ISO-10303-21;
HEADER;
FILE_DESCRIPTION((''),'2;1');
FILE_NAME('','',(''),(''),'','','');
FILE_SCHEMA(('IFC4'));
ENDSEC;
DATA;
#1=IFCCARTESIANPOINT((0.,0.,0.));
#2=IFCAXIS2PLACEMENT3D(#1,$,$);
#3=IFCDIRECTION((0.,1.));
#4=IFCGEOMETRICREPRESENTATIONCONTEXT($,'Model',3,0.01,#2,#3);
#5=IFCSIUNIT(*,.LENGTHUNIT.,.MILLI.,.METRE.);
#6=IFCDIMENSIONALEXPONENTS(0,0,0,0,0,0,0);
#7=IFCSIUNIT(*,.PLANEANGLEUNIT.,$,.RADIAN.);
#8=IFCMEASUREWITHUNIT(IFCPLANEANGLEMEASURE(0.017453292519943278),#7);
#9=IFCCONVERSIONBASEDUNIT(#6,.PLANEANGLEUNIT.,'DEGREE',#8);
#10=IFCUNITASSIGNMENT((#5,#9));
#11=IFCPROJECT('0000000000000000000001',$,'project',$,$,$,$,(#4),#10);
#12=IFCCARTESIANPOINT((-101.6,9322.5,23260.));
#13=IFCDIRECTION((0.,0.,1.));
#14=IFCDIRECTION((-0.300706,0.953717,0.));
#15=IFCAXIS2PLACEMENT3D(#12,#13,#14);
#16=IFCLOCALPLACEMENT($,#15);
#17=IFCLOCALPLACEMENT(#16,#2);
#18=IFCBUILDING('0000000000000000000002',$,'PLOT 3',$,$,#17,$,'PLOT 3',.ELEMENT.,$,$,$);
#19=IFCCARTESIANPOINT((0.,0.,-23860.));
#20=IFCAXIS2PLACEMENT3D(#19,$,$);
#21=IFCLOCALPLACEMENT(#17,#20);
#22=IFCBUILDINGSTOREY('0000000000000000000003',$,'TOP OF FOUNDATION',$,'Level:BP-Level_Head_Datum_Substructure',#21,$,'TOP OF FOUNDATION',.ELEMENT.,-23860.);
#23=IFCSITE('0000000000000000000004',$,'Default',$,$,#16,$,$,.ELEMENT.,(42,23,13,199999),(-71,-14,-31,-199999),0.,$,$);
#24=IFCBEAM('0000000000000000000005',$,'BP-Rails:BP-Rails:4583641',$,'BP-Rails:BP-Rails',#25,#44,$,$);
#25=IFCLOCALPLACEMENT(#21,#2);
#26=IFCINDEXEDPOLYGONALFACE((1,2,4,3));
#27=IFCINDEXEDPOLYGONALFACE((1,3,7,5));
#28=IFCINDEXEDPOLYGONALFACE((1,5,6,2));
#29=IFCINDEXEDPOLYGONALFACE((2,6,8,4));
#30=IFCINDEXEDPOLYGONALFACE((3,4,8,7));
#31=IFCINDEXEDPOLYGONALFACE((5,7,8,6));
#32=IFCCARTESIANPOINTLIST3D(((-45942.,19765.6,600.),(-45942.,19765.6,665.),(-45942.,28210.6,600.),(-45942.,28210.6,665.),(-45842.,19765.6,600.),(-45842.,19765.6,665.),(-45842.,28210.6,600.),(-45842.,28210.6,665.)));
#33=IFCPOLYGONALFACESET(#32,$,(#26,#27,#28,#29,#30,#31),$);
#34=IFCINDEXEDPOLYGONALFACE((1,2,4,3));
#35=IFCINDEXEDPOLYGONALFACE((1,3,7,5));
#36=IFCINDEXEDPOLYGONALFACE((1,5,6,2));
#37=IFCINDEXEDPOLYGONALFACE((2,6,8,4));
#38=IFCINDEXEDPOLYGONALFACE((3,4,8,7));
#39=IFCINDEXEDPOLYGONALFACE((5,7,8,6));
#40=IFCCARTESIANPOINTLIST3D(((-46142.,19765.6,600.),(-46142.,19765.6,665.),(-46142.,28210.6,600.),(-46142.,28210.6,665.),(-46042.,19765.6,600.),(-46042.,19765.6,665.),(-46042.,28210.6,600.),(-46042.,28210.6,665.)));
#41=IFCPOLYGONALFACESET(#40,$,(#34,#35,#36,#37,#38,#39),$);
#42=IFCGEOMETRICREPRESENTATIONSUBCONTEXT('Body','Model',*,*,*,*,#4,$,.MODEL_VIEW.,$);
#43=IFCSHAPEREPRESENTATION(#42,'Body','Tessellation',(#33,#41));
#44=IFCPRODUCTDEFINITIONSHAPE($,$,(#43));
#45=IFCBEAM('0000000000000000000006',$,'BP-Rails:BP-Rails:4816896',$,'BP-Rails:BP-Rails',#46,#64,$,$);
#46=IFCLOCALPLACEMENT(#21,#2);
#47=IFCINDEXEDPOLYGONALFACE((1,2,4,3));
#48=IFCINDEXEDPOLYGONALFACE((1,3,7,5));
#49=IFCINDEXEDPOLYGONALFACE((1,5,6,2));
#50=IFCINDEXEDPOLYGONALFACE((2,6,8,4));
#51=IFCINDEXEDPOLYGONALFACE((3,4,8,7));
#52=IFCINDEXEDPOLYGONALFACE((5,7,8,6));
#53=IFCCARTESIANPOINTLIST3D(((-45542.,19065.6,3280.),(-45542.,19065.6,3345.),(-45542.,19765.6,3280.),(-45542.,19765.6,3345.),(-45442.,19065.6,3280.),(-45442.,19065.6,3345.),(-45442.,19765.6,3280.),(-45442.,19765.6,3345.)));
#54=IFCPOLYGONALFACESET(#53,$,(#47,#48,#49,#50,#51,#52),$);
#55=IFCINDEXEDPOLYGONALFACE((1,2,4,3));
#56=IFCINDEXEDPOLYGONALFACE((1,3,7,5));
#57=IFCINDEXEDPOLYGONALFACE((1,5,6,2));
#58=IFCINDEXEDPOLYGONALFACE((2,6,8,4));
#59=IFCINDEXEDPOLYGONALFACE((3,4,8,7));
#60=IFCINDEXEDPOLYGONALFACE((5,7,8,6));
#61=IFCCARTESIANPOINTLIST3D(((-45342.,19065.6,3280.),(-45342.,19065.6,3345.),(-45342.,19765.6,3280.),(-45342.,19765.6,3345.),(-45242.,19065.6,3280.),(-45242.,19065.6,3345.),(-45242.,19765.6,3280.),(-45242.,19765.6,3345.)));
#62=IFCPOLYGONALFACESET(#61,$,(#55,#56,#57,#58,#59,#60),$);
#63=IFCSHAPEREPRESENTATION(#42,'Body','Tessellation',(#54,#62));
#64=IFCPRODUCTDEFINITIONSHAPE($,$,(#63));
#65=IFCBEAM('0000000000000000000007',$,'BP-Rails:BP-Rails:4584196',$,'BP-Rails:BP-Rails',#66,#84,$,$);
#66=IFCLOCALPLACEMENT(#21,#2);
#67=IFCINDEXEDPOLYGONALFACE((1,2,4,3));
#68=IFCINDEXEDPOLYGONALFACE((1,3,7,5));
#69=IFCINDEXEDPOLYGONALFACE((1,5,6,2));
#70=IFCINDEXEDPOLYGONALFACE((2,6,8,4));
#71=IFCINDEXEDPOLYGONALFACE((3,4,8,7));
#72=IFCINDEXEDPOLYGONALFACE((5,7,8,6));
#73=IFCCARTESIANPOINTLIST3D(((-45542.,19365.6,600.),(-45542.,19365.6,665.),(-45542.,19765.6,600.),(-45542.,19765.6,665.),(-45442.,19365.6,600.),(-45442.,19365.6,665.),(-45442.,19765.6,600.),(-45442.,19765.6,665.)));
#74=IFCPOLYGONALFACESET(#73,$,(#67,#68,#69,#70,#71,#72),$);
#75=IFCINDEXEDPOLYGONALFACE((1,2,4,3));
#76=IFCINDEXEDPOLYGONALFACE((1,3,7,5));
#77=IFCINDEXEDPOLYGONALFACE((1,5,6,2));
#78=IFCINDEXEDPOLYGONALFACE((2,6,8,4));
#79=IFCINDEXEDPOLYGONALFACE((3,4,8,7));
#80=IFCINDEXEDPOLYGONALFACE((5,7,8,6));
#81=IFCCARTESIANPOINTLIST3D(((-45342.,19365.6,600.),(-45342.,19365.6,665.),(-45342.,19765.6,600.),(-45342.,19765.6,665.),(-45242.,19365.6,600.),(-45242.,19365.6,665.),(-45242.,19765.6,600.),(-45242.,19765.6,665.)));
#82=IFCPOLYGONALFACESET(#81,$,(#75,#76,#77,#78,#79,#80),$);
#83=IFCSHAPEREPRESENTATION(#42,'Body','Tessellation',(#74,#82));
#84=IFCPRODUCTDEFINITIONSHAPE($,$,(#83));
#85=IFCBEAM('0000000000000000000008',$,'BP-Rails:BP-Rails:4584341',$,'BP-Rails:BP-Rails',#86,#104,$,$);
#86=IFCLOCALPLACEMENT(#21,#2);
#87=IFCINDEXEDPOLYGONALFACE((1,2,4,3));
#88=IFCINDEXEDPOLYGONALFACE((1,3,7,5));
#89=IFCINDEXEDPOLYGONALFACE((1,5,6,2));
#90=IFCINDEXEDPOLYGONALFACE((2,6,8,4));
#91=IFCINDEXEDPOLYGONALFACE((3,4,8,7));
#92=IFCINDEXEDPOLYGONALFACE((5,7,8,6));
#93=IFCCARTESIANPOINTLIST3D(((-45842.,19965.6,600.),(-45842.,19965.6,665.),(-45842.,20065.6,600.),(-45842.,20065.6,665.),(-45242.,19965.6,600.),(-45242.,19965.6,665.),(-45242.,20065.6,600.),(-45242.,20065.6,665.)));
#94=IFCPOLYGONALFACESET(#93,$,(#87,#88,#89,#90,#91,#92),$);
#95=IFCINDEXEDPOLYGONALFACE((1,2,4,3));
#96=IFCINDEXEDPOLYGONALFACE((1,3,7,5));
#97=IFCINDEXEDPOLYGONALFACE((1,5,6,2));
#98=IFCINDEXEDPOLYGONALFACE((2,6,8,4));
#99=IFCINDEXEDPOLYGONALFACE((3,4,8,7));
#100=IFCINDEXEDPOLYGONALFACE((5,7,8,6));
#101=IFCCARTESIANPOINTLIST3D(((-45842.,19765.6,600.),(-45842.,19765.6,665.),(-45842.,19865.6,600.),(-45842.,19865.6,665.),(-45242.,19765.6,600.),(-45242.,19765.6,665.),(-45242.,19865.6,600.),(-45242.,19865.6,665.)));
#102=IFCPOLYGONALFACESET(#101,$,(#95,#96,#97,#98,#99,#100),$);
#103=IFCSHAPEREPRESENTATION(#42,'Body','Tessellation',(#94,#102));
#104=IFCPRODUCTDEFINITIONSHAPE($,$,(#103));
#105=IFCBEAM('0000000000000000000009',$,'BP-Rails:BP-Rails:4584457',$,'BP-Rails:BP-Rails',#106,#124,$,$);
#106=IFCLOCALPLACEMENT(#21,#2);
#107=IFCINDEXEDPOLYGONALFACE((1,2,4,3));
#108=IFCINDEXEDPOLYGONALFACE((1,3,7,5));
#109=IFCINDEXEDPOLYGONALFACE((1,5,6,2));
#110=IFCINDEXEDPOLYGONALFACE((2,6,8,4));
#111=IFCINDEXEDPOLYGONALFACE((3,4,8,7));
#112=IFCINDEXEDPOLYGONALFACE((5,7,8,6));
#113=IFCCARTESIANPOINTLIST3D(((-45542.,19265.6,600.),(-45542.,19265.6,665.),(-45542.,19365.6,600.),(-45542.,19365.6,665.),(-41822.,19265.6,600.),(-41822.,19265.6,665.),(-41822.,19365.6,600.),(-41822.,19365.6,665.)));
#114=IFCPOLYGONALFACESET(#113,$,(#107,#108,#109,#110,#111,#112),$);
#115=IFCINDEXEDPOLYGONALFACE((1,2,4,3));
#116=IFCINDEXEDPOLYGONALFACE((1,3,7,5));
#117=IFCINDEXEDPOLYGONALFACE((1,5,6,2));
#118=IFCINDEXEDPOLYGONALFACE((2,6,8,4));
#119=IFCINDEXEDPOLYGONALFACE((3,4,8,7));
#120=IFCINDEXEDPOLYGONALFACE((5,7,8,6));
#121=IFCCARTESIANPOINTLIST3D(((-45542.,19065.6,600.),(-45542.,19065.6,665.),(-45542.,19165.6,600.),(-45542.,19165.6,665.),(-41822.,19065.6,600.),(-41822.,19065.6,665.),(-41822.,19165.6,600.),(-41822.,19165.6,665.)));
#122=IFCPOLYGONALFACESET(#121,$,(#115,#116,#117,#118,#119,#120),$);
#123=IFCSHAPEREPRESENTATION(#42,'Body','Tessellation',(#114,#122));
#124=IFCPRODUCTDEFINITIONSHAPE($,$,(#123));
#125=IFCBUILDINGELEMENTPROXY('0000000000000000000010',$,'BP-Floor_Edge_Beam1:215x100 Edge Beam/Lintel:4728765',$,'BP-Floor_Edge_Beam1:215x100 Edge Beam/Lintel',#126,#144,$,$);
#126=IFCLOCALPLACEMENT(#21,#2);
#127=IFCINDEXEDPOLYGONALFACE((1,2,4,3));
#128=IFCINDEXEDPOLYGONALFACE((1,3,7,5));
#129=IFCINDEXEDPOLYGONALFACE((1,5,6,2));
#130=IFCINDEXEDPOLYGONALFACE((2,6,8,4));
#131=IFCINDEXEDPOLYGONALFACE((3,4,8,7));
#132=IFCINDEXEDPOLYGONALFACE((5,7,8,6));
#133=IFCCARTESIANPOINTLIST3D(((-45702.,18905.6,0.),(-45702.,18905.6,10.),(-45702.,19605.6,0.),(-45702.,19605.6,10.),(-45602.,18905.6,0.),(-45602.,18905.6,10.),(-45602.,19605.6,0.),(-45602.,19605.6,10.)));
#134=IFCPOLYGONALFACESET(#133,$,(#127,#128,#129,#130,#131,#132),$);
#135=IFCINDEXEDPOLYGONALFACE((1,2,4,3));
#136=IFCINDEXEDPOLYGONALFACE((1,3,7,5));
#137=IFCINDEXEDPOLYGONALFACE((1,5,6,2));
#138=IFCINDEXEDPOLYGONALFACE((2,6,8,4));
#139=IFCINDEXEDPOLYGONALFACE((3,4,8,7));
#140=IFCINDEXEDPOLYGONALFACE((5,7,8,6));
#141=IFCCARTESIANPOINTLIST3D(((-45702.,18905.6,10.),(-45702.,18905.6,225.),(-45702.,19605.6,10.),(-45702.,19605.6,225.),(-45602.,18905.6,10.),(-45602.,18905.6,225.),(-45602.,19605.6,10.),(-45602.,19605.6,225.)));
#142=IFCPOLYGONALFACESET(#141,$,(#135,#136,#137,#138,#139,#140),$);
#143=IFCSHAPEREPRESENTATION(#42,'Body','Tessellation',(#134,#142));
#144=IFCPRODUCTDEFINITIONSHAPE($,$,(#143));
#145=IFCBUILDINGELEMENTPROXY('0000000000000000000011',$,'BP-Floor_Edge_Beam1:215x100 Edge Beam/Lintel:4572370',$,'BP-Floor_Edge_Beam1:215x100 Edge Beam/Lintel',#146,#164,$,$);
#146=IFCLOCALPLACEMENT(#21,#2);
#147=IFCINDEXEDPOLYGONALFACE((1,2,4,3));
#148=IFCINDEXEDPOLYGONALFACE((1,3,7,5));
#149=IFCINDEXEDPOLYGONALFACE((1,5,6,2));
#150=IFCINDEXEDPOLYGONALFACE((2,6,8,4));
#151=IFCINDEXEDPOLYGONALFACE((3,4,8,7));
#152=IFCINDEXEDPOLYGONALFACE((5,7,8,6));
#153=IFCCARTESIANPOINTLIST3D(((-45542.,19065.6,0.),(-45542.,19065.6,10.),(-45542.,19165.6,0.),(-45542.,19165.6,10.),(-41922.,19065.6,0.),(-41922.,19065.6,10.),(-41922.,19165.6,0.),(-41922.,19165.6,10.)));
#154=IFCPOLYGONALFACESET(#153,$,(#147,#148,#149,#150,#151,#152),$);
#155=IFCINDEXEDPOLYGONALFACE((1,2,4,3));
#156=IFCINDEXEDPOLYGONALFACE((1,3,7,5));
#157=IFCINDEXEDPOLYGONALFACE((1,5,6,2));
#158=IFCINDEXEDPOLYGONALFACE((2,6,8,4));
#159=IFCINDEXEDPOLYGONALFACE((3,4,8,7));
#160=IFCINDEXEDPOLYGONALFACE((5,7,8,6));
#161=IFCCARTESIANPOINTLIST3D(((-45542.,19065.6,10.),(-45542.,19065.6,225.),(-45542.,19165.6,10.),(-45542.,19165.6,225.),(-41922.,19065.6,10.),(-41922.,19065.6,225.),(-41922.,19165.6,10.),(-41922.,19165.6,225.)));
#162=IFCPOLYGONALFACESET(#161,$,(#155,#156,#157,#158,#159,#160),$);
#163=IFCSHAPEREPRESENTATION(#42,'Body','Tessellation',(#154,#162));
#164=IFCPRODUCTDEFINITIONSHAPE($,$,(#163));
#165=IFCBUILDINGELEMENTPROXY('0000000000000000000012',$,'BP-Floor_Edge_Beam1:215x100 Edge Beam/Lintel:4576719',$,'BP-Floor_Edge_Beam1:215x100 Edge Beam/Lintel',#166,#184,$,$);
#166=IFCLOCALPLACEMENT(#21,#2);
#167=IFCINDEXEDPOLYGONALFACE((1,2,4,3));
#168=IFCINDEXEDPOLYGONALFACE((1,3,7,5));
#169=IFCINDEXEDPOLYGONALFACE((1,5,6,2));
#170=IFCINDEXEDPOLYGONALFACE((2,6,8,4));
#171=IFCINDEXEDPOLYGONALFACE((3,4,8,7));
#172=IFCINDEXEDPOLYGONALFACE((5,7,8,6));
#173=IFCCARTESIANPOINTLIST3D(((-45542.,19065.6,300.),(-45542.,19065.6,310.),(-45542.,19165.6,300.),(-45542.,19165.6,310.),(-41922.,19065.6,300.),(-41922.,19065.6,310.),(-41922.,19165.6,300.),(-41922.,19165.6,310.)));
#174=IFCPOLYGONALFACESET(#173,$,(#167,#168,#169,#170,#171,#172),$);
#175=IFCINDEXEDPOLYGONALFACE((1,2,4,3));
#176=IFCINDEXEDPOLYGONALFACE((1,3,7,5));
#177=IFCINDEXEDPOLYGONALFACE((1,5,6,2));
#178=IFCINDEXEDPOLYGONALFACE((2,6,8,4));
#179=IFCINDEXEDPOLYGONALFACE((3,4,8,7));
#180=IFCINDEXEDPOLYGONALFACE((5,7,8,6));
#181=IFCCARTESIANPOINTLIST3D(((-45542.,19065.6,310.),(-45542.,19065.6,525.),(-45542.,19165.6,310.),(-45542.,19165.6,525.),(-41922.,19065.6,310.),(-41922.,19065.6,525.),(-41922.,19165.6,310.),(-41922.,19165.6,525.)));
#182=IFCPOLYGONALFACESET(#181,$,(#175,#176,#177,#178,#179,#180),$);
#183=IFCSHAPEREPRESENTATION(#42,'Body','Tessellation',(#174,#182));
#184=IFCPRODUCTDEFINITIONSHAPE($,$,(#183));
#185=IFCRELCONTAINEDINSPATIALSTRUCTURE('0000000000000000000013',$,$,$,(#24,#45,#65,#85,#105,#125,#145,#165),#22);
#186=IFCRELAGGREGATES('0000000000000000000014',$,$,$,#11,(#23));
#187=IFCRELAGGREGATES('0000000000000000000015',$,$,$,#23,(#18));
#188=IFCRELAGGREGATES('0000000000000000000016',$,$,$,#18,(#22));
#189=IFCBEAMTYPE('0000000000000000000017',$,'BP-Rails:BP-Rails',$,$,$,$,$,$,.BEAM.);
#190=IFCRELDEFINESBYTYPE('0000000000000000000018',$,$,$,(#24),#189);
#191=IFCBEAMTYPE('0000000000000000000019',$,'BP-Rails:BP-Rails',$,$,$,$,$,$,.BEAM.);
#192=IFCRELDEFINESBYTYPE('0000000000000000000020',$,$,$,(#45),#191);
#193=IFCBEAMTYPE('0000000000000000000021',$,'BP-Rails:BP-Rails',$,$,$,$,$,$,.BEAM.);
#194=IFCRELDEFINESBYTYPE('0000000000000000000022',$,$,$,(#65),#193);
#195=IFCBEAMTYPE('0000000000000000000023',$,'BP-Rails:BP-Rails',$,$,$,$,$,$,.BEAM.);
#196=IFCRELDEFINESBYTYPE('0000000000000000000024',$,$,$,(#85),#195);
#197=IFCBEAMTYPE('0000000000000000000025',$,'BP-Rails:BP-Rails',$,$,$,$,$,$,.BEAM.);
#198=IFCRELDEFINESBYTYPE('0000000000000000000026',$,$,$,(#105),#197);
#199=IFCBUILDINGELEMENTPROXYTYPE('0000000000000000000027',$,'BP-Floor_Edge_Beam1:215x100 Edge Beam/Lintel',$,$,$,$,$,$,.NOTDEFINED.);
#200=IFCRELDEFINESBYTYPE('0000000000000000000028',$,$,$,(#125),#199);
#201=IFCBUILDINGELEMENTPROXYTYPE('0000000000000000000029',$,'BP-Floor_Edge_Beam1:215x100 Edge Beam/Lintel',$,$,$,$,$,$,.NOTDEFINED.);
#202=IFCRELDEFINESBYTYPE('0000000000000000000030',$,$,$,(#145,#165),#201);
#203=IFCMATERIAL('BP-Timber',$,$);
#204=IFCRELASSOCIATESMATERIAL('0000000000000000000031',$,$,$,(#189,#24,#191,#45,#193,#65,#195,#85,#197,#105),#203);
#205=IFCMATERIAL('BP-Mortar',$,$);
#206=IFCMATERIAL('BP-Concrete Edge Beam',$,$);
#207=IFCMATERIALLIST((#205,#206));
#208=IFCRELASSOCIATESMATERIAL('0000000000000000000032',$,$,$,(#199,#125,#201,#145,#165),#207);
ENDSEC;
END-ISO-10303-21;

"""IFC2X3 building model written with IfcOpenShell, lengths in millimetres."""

from ifc_helpers import new_model, entity, si_unit, converted_unit, direction, frame, frame_2d, origin, origin_2d_with_axis, place, context, subcontext, project, spatial, rectangle, extrude, source, transform, mapped, material, material_list, type_object, type_shapes, element, save


model = new_model("IFC2X3")

# Units and contexts
model_context = context("Model", 3, precision=0.01, world=origin(), true_north=direction((0.0, 1.0)))
body_context = subcontext(model_context, "Body", "Model", "MODEL_VIEW")
ifc_project = project(units=[si_unit("LENGTHUNIT", "METRE", prefix="MILLI"), converted_unit("PLANEANGLEUNIT", "DEGREE", entity("IfcPlaneAngleMeasure", 0.017453292519943278), si_unit("PLANEANGLEUNIT", "RADIAN"), dimensions=[0, 0, 0, 0, 0, 0, 0])], contexts=[model_context])

# Site, building, storey
site_placement = place(None, frame((-101.6, 9322.5, 23260.0), z_axis=(0.0, 0.0, 1.0), x_axis=(-0.300706, 0.953717, 0.0)))
site = spatial("IfcSite", under=ifc_project, at=site_placement, Name="Default", CompositionType="ELEMENT", RefLatitude=(42, 23, 13, 199999), RefLongitude=(-71, -14, -31, -199999), RefElevation=0.0)
building_placement = place(site_placement, origin())
building = spatial("IfcBuilding", under=site, at=building_placement, Name="PLOT 3", LongName="PLOT 3", CompositionType="ELEMENT")
storey_placement = place(building_placement, frame((0.0, 0.0, -23860.0)))
storey = spatial("IfcBuildingStorey", under=building, at=storey_placement, Name="TOP OF FOUNDATION", ObjectType="Level:BP-Level_Head_Datum_Substructure", LongName="TOP OF FOUNDATION", CompositionType="ELEMENT", Elevation=-23860.0)

# Beams
ifc_material_1 = material(Name="BP-Timber")
beam_type_1 = type_object("IfcBeamType", Name="BP-Rails:BP-Rails", PredefinedType="BEAM", material=ifc_material_1)
shared_shape_1 = source(origin(), body_context, "Body", "SweptSolid", [
    extrude(rectangle(XDim=65.0, YDim=100.0, at=frame_2d((0.0, 0.0), x_axis=(1.0, 0.0))), frame((-4222.5, 100.0, -32.5), z_axis=(1.0, 0.0, 0.0), x_axis=(0.0, 0.0, -1.0)), (0.0, 0.0, 1.0), 8445.0),
    extrude(rectangle(XDim=65.0, YDim=100.0, at=origin_2d_with_axis()), frame((-4222.5, -100.0, -32.5), z_axis=(1.0, 0.0, 0.0), x_axis=(0.0, 0.0, -1.0)), (0.0, 0.0, 1.0), 8445.0),
])
type_shapes(beam_type_1, [shared_shape_1])
beam_1_placement = place(storey_placement, frame((-45992.0, 23988.1, 665.0), z_axis=(0.0, 0.0, 1.0), x_axis=(0.0, -1.0, 0.0)))
element("IfcBeam", 1, at=beam_1_placement, inside=storey, type_object=beam_type_1, material=ifc_material_1, Name="BP-Rails:BP-Rails:4583641", ObjectType="BP-Rails:BP-Rails", context=body_context, shape_type="MappedRepresentation", body=[
    mapped(shared_shape_1, transform((0.0, 0.0, 0.0), scale=1.0)),
])
beam_type_2 = type_object("IfcBeamType", Name="BP-Rails:BP-Rails", PredefinedType="BEAM", material=ifc_material_1)
shared_shape_2 = source(origin(), body_context, "Body", "SweptSolid", [
    extrude(rectangle(XDim=65.0, YDim=100.0, at=frame_2d((0.0, 0.0), x_axis=(1.0, 0.0))), frame((-350.0, 100.0, -32.5), z_axis=(1.0, 0.0, 0.0), x_axis=(0.0, 0.0, -1.0)), (0.0, 0.0, 1.0), 700.0),
    extrude(rectangle(XDim=65.0, YDim=100.0, at=origin_2d_with_axis()), frame((-350.0, -100.0, -32.5), z_axis=(1.0, 0.0, 0.0), x_axis=(0.0, 0.0, -1.0)), (0.0, 0.0, 1.0), 700.0),
])
type_shapes(beam_type_2, [shared_shape_2])
beam_2_placement = place(storey_placement, frame((-45392.0, 19415.6, 3345.0), z_axis=(0.0, 0.0, 1.0), x_axis=(0.0, 1.0, 0.0)))
element("IfcBeam", 2, at=beam_2_placement, inside=storey, type_object=beam_type_2, material=ifc_material_1, Name="BP-Rails:BP-Rails:4816896", ObjectType="BP-Rails:BP-Rails", context=body_context, shape_type="MappedRepresentation", body=[
    mapped(shared_shape_2, transform((0.0, 0.0, 0.0), scale=1.0)),
])
beam_type_3 = type_object("IfcBeamType", Name="BP-Rails:BP-Rails", PredefinedType="BEAM", material=ifc_material_1)
shared_shape_3 = source(origin(), body_context, "Body", "SweptSolid", [
    extrude(rectangle(XDim=65.0, YDim=100.0, at=frame_2d((0.0, 0.0), x_axis=(1.0, 0.0))), frame((-200.0, 100.0, -32.5), z_axis=(1.0, 0.0, 0.0), x_axis=(0.0, 0.0, -1.0)), (0.0, 0.0, 1.0), 400.0),
    extrude(rectangle(XDim=65.0, YDim=100.0, at=origin_2d_with_axis()), frame((-200.0, -100.0, -32.5), z_axis=(1.0, 0.0, 0.0), x_axis=(0.0, 0.0, -1.0)), (0.0, 0.0, 1.0), 400.0),
])
type_shapes(beam_type_3, [shared_shape_3])
beam_3_placement = place(storey_placement, frame((-45392.0, 19565.6, 665.0), z_axis=(0.0, 0.0, 1.0), x_axis=(0.0, 1.0, 0.0)))
element("IfcBeam", 3, at=beam_3_placement, inside=storey, type_object=beam_type_3, material=ifc_material_1, Name="BP-Rails:BP-Rails:4584196", ObjectType="BP-Rails:BP-Rails", context=body_context, shape_type="MappedRepresentation", body=[
    mapped(shared_shape_3, transform((0.0, 0.0, 0.0), scale=1.0)),
])
beam_type_4 = type_object("IfcBeamType", Name="BP-Rails:BP-Rails", PredefinedType="BEAM", material=ifc_material_1)
shared_shape_4 = source(origin(), body_context, "Body", "SweptSolid", [
    extrude(rectangle(XDim=65.0, YDim=100.0, at=frame_2d((0.0, 0.0), x_axis=(1.0, 0.0))), frame((-300.0, 100.0, -32.5), z_axis=(1.0, 0.0, 0.0), x_axis=(0.0, 0.0, -1.0)), (0.0, 0.0, 1.0), 600.0),
    extrude(rectangle(XDim=65.0, YDim=100.0, at=origin_2d_with_axis()), frame((-300.0, -100.0, -32.5), z_axis=(1.0, 0.0, 0.0), x_axis=(0.0, 0.0, -1.0)), (0.0, 0.0, 1.0), 600.0),
])
type_shapes(beam_type_4, [shared_shape_4])
beam_4_placement = place(storey_placement, frame((-45542.0, 19915.6, 665.0)))
element("IfcBeam", 4, at=beam_4_placement, inside=storey, type_object=beam_type_4, material=ifc_material_1, Name="BP-Rails:BP-Rails:4584341", ObjectType="BP-Rails:BP-Rails", context=body_context, shape_type="MappedRepresentation", body=[
    mapped(shared_shape_4, transform((0.0, 0.0, 0.0), scale=1.0)),
])
beam_type_5 = type_object("IfcBeamType", Name="BP-Rails:BP-Rails", PredefinedType="BEAM", material=ifc_material_1)
shared_shape_5 = source(origin(), body_context, "Body", "SweptSolid", [
    extrude(rectangle(XDim=65.0, YDim=100.0, at=frame_2d((0.0, 0.0), x_axis=(1.0, 0.0))), frame((-1860.0, 100.0, -32.5), z_axis=(1.0, 0.0, 0.0), x_axis=(0.0, 0.0, -1.0)), (0.0, 0.0, 1.0), 3720.0),
    extrude(rectangle(XDim=65.0, YDim=100.0, at=origin_2d_with_axis()), frame((-1860.0, -100.0, -32.5), z_axis=(1.0, 0.0, 0.0), x_axis=(0.0, 0.0, -1.0)), (0.0, 0.0, 1.0), 3720.0),
])
type_shapes(beam_type_5, [shared_shape_5])
beam_5_placement = place(storey_placement, frame((-43682.0, 19215.6, 665.0)))
element("IfcBeam", 5, at=beam_5_placement, inside=storey, type_object=beam_type_5, material=ifc_material_1, Name="BP-Rails:BP-Rails:4584457", ObjectType="BP-Rails:BP-Rails", context=body_context, shape_type="MappedRepresentation", body=[
    mapped(shared_shape_5, transform((0.0, 0.0, 0.0), scale=1.0)),
])

# Building element proxies
ifc_material_2 = material(Name="BP-Mortar")
ifc_material_3 = material(Name="BP-Concrete Edge Beam")
ifc_material_list = material_list([ifc_material_2, ifc_material_3])
building_element_proxy_type_1 = type_object("IfcBuildingElementProxyType", Name="BP-Floor_Edge_Beam1:215x100 Edge Beam/Lintel", PredefinedType="NOTDEFINED", material=ifc_material_list)
shared_shape_6 = source(origin(), body_context, "Body", "SweptSolid", [
    extrude(rectangle(XDim=100.0, YDim=700.0, at=origin_2d_with_axis()), frame((0.0, 0.0, 0.0), z_axis=(0.0, 0.0, 1.0), x_axis=(0.0, 1.0, 0.0)), (0.0, 0.0, 1.0), 10.0),
    extrude(rectangle(XDim=100.0, YDim=700.0, at=origin_2d_with_axis()), frame((0.0, 0.0, 10.0), z_axis=(0.0, 0.0, 1.0), x_axis=(0.0, 1.0, 0.0)), (0.0, 0.0, 1.0), 215.0),
])
type_shapes(building_element_proxy_type_1, [shared_shape_6])
proxy_1_placement = place(storey_placement, frame((-45652.0, 19255.6, 0.0), z_axis=(0.0, 0.0, 1.0), x_axis=(0.0, 1.0, 0.0)))
element("IfcBuildingElementProxy", 6, at=proxy_1_placement, inside=storey, type_object=building_element_proxy_type_1, material=ifc_material_list, Name="BP-Floor_Edge_Beam1:215x100 Edge Beam/Lintel:4728765", ObjectType="BP-Floor_Edge_Beam1:215x100 Edge Beam/Lintel", context=body_context, shape_type="MappedRepresentation", body=[
    mapped(shared_shape_6, transform((0.0, 0.0, 0.0), scale=1.0)),
])
building_element_proxy_type_2 = type_object("IfcBuildingElementProxyType", Name="BP-Floor_Edge_Beam1:215x100 Edge Beam/Lintel", PredefinedType="NOTDEFINED", material=ifc_material_list)
shared_shape_7 = source(origin(), body_context, "Body", "SweptSolid", [
    extrude(rectangle(XDim=100.0, YDim=3620.0, at=origin_2d_with_axis()), frame((0.0, 0.0, 0.0), z_axis=(0.0, 0.0, 1.0), x_axis=(0.0, 1.0, 0.0)), (0.0, 0.0, 1.0), 10.0),
    extrude(rectangle(XDim=100.0, YDim=3620.0, at=origin_2d_with_axis()), frame((0.0, 0.0, 10.0), z_axis=(0.0, 0.0, 1.0), x_axis=(0.0, 1.0, 0.0)), (0.0, 0.0, 1.0), 215.0),
])
type_shapes(building_element_proxy_type_2, [shared_shape_7])
for number, where, z_axis, x_axis, name in (
    (7, (-43732.0, 19115.6, 0.0), (0.0, 0.0, 1.0), (-1.0, 0.0, 0.0), "BP-Floor_Edge_Beam1:215x100 Edge Beam/Lintel:4572370"),
    (8, (-43732.0, 19115.6, 300.0), (0.0, 0.0, 1.0), (-1.0, 0.0, 0.0), "BP-Floor_Edge_Beam1:215x100 Edge Beam/Lintel:4576719"),
):
    element("IfcBuildingElementProxy", number, at=place(storey_placement, frame(where, z_axis=z_axis, x_axis=x_axis)), inside=storey, type_object=building_element_proxy_type_2, material=ifc_material_list, Name=name, ObjectType="BP-Floor_Edge_Beam1:215x100 Edge Beam/Lintel", context=body_context, shape_type="MappedRepresentation", body=[
        mapped(shared_shape_7, transform((0.0, 0.0, 0.0), scale=1.0)),
    ])

save(model, "model.ifc")
